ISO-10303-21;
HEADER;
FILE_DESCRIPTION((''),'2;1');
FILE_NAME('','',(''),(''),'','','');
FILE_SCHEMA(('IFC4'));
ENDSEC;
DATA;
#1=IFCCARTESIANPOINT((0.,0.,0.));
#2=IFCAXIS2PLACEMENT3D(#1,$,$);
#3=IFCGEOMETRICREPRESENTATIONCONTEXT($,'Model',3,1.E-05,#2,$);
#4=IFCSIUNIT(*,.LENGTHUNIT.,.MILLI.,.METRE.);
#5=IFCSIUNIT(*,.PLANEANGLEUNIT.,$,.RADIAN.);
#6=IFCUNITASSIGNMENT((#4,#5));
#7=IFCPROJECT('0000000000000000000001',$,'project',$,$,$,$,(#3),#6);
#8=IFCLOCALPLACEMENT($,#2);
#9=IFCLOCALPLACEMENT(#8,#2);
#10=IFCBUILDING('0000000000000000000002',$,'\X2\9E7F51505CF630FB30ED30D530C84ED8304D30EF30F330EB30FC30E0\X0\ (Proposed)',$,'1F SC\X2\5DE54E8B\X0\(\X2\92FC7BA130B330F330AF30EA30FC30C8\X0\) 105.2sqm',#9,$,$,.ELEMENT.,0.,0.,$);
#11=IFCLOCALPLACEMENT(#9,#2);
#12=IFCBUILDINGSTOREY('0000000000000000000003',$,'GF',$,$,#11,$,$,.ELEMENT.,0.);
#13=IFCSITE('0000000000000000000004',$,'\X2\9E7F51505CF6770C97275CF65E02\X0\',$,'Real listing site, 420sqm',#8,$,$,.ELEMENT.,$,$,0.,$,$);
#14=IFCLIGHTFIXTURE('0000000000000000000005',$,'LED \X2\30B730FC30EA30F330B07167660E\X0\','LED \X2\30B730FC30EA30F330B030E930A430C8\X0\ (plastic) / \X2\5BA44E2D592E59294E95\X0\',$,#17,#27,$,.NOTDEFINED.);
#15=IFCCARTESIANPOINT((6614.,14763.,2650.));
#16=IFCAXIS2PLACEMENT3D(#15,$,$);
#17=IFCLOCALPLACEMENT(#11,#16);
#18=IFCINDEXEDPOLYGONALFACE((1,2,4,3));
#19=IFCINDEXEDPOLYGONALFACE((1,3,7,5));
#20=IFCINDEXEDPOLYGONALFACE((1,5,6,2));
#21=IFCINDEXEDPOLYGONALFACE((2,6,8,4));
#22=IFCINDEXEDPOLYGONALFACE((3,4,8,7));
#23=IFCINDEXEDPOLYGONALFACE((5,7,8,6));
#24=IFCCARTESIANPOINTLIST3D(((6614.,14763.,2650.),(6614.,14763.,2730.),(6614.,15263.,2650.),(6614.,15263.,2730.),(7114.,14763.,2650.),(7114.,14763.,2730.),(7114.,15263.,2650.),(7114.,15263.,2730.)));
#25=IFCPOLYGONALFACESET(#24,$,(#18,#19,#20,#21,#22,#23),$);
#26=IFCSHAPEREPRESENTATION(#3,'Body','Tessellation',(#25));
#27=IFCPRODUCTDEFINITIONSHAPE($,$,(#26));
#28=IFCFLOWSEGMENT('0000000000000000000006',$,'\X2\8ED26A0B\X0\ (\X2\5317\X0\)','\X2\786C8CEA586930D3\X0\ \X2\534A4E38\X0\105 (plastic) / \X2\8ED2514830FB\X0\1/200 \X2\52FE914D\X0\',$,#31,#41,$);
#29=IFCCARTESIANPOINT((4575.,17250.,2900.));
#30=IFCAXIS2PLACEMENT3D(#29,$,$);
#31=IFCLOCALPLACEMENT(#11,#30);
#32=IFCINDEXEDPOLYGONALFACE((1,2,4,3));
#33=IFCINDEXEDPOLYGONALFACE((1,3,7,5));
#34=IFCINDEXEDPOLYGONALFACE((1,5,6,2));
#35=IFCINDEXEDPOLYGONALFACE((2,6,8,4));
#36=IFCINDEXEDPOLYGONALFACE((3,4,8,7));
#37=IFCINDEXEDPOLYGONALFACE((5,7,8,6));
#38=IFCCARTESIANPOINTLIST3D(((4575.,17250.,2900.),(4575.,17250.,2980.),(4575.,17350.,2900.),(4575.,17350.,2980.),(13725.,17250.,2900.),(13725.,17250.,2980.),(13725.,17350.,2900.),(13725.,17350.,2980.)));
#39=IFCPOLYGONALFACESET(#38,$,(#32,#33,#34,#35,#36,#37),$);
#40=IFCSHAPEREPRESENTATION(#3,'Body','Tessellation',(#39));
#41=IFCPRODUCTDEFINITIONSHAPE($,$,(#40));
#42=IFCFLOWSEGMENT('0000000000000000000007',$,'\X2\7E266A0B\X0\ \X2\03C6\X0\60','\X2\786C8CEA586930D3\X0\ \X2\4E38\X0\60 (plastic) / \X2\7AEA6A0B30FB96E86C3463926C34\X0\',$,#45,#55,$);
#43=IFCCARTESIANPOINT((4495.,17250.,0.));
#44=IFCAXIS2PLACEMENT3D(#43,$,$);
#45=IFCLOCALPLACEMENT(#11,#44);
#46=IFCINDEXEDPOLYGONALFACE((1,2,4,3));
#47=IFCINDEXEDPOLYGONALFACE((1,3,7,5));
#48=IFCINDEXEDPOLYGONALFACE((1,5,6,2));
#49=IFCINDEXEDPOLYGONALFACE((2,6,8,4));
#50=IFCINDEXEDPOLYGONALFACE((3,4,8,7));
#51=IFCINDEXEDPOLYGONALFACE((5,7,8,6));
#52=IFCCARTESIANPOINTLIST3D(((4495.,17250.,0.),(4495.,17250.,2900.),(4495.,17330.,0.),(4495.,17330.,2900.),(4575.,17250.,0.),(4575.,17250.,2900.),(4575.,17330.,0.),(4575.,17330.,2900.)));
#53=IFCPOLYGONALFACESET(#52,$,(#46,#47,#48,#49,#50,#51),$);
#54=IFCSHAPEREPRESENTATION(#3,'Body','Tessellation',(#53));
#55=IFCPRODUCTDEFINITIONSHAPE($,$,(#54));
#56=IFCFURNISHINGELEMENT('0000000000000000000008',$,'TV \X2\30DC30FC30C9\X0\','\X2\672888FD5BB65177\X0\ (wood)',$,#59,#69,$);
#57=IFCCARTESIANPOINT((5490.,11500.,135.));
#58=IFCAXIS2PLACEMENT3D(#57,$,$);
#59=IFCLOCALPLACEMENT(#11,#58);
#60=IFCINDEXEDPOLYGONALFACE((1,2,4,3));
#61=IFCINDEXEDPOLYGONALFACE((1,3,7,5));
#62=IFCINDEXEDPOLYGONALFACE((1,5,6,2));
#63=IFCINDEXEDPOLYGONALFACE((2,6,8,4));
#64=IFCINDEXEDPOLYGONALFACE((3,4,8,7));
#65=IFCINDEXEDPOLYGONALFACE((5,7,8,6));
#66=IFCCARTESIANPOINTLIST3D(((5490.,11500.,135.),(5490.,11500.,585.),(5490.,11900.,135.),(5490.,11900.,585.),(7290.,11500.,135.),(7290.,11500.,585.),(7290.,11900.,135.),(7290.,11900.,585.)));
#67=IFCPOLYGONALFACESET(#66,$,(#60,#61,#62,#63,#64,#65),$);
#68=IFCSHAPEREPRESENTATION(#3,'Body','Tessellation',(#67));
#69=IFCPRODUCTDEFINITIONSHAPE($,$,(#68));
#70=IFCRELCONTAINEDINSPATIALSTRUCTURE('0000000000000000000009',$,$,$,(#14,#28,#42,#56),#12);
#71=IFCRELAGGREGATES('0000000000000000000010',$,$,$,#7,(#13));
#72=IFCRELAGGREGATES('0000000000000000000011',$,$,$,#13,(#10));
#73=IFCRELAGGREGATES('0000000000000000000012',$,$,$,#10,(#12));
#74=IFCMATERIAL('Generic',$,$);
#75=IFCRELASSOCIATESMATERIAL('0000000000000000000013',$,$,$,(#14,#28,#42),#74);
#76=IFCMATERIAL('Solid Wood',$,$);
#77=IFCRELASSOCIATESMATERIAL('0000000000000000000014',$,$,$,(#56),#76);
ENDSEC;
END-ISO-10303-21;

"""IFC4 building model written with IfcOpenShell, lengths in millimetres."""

from ifc_helpers import new_model, si_unit, frame, frame_2d, origin, place, context, project, spatial, rectangle, extrude, material, element, save


model = new_model("IFC4")

# Units and contexts
model_context = context("Model", 3, precision=1e-05, world=origin())
ifc_project = project(units=[si_unit("LENGTHUNIT", "METRE", prefix="MILLI"), si_unit("PLANEANGLEUNIT", "RADIAN")], contexts=[model_context])

# Site, building, storey
site_placement = place(None, origin())
site = spatial("IfcSite", under=ifc_project, at=site_placement, Name="鹿児島県霧島市", ObjectType="Real listing site, 420sqm", CompositionType="ELEMENT", RefElevation=0.0)
building_placement = place(site_placement, origin())
building = spatial("IfcBuilding", under=site, at=building_placement, Name="鹿児島・ロフト付きワンルーム (Proposed)", ObjectType="1F SC工事(鋼管コンクリート) 105.2sqm", CompositionType="ELEMENT", ElevationOfRefHeight=0.0, ElevationOfTerrain=0.0)
storey_placement = place(building_placement, origin())
storey = spatial("IfcBuildingStorey", under=building, at=storey_placement, Name="GF", CompositionType="ELEMENT", Elevation=0.0)

# Shared definitions
ifc_material_1 = material(Name="Solid Wood")

# Shared definitions
ifc_material_2 = material(Name="Generic")

# Light fixture
light_fixture_placement = place(storey_placement, frame((6614.0, 14763.0, 2650.0)))
element("IfcLightFixture", 1, at=light_fixture_placement, inside=storey, material=ifc_material_2, Name="LED シーリング照明", Description="LED シーリングライト (plastic) / 室中央天井", PredefinedType="NOTDEFINED", context=model_context, shape_type="SweptSolid", body=[
    extrude(rectangle(XDim=500.0, YDim=500.0, at=frame_2d((250.0, 250.0))), frame((6614.0, 14763.0, 2650.0)), (0.0, 0.0, 1.0), 80.0),
])

# Flow segments
flow_segment_1_placement = place(storey_placement, frame((4575.0, 17250.0, 2900.0)))
element("IfcFlowSegment", 2, at=flow_segment_1_placement, inside=storey, material=ifc_material_2, Name="軒樋 (北)", Description="硬質塩ビ 半丸105 (plastic) / 軒先・1/200 勾配", context=model_context, shape_type="SweptSolid", body=[
    extrude(rectangle(XDim=9150.0, YDim=100.0, at=frame_2d((4575.0, 50.0))), frame((4575.0, 17250.0, 2900.0)), (0.0, 0.0, 1.0), 80.0),
])
flow_segment_2_placement = place(storey_placement, frame((4495.0, 17250.0, 0.0)))
element("IfcFlowSegment", 3, at=flow_segment_2_placement, inside=storey, material=ifc_material_2, Name="縦樋 φ60", Description="硬質塩ビ 丸60 (plastic) / 竪樋・雨水排水", context=model_context, shape_type="SweptSolid", body=[
    extrude(rectangle(XDim=80.0, YDim=80.0, at=frame_2d((40.0, 40.0))), frame((4495.0, 17250.0, 0.0)), (0.0, 0.0, 1.0), 2900.0),
])

# Furnishing element
furnishing_placement = place(storey_placement, frame((5490.0, 11500.0, 135.0)))
element("IfcFurnishingElement", 4, at=furnishing_placement, inside=storey, material=ifc_material_1, Name="TV ボード", Description="木製家具 (wood)", context=model_context, shape_type="SweptSolid", body=[
    extrude(rectangle(XDim=1800.0, YDim=400.0, at=frame_2d((900.0, 200.0))), frame((5490.0, 11500.0, 135.0)), (0.0, 0.0, 1.0), 450.0),
])

save(model, "model.ifc")
